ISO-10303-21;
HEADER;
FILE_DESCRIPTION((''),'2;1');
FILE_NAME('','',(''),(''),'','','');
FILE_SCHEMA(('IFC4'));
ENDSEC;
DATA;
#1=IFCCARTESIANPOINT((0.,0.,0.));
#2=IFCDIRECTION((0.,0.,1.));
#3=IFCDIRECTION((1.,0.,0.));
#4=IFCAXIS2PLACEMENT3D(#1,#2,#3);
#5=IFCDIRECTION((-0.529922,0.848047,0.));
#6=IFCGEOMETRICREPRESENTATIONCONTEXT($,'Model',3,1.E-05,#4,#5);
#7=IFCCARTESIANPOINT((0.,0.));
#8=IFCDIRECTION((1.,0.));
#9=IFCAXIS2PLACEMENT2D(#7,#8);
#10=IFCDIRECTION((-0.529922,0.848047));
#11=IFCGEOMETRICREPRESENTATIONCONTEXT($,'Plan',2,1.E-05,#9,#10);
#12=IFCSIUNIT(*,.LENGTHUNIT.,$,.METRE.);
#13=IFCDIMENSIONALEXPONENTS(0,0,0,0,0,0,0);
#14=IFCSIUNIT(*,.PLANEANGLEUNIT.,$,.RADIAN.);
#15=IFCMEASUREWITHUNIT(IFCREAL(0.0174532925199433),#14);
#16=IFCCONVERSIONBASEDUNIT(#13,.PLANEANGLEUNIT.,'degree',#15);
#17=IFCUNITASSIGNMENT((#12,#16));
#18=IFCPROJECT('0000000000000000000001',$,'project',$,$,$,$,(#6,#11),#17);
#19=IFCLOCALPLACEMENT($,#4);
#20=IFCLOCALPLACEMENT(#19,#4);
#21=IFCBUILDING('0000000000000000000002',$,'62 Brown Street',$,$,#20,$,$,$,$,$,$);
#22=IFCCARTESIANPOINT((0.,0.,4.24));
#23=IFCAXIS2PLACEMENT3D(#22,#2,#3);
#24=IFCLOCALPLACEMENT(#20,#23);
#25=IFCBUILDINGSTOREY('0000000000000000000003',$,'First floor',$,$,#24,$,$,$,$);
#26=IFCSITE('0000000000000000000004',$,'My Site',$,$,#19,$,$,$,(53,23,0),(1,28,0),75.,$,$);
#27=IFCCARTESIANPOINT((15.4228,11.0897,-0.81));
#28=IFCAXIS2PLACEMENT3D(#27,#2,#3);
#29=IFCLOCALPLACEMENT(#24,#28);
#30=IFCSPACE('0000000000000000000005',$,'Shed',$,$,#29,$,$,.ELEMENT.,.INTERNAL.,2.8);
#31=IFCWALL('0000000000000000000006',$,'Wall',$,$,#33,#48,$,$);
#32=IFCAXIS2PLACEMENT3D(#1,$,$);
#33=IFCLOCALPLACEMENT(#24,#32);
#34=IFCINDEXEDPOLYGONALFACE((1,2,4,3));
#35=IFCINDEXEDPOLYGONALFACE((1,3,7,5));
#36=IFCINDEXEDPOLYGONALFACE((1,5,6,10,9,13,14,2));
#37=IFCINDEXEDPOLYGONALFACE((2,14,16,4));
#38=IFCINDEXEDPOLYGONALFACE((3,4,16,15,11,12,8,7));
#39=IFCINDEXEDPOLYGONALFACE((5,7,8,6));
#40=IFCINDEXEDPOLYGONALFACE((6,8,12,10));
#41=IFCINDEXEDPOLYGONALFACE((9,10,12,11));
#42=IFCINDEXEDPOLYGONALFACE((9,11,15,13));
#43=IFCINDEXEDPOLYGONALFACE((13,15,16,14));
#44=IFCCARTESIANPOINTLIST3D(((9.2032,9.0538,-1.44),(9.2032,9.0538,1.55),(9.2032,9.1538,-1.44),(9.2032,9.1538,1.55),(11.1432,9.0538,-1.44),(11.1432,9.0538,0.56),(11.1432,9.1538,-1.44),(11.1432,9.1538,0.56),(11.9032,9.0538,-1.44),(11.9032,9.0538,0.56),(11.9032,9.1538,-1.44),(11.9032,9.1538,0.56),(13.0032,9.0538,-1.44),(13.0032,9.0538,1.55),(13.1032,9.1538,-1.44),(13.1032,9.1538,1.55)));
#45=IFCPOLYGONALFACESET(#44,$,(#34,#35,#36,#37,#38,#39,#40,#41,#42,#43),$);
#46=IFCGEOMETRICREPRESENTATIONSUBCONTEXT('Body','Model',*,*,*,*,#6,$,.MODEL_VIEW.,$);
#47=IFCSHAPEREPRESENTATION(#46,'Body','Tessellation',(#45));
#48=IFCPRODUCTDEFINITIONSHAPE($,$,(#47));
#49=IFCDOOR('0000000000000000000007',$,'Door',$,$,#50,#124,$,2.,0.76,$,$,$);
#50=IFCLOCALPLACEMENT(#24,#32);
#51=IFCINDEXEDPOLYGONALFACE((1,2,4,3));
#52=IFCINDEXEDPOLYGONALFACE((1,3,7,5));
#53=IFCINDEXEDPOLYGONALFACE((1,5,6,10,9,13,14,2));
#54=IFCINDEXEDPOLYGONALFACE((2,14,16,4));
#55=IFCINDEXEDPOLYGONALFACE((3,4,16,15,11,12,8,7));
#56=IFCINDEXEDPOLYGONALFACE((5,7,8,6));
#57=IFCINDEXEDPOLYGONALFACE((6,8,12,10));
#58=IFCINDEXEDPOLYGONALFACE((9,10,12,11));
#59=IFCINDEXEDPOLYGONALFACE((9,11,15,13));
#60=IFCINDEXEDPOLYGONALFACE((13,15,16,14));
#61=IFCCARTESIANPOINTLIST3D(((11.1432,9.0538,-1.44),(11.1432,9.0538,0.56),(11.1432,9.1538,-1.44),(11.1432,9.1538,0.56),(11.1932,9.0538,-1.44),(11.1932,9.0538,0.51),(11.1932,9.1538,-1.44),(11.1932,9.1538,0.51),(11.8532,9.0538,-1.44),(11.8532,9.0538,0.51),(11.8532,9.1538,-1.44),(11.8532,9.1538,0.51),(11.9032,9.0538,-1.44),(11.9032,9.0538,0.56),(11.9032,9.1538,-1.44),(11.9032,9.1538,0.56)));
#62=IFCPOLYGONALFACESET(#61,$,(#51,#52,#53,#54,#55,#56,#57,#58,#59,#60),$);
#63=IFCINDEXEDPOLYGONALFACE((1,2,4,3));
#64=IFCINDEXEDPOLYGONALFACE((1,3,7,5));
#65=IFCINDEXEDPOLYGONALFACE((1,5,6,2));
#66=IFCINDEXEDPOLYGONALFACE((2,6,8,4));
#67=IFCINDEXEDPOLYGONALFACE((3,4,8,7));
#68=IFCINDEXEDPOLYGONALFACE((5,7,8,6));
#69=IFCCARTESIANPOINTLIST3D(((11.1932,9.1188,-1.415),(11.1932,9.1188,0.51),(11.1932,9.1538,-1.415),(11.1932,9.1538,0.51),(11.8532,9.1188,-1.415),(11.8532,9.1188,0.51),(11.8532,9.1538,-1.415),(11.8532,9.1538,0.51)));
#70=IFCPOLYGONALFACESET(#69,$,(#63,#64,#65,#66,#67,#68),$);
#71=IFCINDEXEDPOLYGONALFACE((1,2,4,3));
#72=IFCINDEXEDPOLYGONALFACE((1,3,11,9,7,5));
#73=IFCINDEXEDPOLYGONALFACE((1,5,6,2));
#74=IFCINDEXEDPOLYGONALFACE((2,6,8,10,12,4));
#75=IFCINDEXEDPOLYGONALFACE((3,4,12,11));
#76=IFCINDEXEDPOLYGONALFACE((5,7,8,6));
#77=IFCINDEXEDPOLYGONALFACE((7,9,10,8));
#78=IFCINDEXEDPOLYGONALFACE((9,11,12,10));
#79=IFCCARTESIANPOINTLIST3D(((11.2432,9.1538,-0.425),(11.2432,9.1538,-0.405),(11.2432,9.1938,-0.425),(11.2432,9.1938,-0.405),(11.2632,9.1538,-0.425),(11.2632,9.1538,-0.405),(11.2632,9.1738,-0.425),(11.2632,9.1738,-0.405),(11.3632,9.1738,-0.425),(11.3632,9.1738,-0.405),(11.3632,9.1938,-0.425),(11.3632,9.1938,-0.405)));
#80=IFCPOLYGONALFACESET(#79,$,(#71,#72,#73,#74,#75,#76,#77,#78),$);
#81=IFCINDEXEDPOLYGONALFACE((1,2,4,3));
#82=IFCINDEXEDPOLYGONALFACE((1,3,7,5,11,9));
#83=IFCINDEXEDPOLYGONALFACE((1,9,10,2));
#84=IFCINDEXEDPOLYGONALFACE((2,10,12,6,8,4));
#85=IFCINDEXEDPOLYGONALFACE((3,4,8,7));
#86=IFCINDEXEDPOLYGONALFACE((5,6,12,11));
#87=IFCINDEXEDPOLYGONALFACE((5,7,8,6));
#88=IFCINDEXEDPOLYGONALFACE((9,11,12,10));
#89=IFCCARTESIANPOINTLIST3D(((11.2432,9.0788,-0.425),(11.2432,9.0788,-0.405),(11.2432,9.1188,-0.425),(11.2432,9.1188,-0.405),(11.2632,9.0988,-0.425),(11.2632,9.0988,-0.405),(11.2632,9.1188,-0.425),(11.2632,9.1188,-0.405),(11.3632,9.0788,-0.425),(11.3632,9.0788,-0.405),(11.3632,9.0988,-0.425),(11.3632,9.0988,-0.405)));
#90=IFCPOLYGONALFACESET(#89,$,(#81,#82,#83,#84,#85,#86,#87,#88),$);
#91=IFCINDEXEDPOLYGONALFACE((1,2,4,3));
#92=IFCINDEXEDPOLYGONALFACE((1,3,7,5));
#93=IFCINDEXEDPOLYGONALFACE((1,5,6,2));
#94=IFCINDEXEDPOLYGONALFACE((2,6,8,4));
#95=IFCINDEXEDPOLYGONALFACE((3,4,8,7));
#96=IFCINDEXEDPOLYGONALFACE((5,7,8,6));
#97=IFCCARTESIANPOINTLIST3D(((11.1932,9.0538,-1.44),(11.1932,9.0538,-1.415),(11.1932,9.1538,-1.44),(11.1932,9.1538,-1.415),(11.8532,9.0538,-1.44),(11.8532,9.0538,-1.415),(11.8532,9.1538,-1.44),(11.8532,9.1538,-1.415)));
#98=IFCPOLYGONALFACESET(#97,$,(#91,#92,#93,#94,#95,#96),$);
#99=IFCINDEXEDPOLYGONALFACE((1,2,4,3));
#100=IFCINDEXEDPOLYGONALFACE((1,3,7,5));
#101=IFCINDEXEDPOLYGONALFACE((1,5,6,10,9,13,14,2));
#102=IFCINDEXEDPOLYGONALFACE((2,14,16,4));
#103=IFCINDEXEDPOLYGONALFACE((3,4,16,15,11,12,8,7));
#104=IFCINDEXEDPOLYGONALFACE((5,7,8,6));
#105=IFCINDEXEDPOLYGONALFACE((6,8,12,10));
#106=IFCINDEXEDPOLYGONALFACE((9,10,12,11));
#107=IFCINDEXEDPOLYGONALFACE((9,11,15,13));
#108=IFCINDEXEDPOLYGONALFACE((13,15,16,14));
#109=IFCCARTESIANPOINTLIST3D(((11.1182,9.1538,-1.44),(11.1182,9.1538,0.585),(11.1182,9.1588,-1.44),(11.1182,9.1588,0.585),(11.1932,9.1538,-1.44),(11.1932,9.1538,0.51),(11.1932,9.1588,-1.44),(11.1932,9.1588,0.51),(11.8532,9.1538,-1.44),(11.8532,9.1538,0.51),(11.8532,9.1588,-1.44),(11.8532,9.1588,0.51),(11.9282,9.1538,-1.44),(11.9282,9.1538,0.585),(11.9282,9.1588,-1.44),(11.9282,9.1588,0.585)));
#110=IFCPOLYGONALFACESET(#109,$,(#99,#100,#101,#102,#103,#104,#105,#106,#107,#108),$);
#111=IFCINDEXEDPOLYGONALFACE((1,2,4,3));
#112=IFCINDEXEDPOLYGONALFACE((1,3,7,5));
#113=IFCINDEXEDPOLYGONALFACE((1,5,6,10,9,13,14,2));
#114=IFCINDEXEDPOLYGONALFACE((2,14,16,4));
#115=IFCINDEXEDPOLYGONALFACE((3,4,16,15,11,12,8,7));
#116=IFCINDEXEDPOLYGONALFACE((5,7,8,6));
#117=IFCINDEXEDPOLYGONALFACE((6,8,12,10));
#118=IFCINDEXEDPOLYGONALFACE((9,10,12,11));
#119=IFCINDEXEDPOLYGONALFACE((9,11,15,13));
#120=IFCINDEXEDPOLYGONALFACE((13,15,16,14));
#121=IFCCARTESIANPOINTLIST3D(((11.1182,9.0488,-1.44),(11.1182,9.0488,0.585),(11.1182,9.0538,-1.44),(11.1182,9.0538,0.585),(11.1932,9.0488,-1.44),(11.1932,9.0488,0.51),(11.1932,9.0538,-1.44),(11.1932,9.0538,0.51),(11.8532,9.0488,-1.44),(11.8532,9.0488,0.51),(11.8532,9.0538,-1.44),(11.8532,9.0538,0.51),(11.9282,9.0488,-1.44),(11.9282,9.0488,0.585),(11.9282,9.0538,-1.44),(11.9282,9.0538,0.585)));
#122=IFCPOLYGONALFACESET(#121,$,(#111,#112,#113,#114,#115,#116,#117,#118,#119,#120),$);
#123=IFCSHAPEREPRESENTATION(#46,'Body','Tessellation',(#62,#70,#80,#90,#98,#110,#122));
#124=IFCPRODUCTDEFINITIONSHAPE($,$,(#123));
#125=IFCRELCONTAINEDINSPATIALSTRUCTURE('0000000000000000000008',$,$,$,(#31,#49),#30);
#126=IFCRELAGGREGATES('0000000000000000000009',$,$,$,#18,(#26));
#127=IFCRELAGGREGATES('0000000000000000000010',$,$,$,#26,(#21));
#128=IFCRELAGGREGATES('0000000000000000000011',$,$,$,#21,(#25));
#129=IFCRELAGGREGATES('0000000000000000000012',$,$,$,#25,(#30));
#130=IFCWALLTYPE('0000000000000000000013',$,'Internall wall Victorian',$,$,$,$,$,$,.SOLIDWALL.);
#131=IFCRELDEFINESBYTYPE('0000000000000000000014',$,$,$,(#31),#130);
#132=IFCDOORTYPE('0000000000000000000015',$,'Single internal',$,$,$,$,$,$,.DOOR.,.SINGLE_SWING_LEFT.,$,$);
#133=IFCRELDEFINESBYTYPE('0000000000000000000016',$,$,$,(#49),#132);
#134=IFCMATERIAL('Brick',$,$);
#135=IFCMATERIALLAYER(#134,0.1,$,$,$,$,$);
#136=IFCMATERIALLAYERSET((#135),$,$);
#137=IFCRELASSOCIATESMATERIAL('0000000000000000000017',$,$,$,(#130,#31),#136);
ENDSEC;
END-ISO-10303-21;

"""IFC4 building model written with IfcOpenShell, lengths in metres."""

from ifc_helpers import new_model, entity, si_unit, converted_unit, direction, frame, origin_with_axes, origin_2d_with_axis, place, context, subcontext, project, spatial, line, indexed_curve, outline, extrude, clip, halfspace, shape, source, transform, mapped, material, layer, layer_set, layer_usage, type_object, type_shapes, element, fill, save


model = new_model("IFC4")

# Units and contexts
model_context = context("Model", 3, precision=1e-05, world=origin_with_axes(), true_north=direction((-0.529922, 0.848047, 0.0)))
plan_context = context("Plan", 2, precision=1e-05, world=origin_2d_with_axis(), true_north=direction((-0.529922, 0.848047)))
body_context_1 = subcontext(model_context, "Body", "Model", "MODEL_VIEW")
body_context_2 = subcontext(plan_context, "Body", "Plan", "PLAN_VIEW")
ifc_project = project(units=[si_unit("LENGTHUNIT", "METRE"), converted_unit("PLANEANGLEUNIT", "degree", entity("IfcReal", 0.0174532925199433), si_unit("PLANEANGLEUNIT", "RADIAN"), dimensions=[0, 0, 0, 0, 0, 0, 0])], contexts=[model_context, plan_context])

# Site, building, storey, space
site_placement = place(None, origin_with_axes())
site = spatial("IfcSite", under=ifc_project, at=site_placement, Name="My Site", RefLatitude=(53, 23, 0), RefLongitude=(1, 28, 0), RefElevation=75.0)
building_placement = place(site_placement, origin_with_axes())
building = spatial("IfcBuilding", under=site, at=building_placement, Name="62 Brown Street")
storey_placement = place(building_placement, frame((0.0, 0.0, 4.24), z_axis=(0.0, 0.0, 1.0), x_axis=(1.0, 0.0, 0.0)))
storey = spatial("IfcBuildingStorey", under=building, at=storey_placement, Name="First floor")
space_placement = place(storey_placement, frame((15.4228, 11.0897, -0.81), z_axis=(0.0, 0.0, 1.0), x_axis=(1.0, 0.0, 0.0)))
space = spatial("IfcSpace", under=storey, at=space_placement, Name="Shed", CompositionType="ELEMENT", PredefinedType="INTERNAL", ElevationWithFlooring=2.8)

# Shared definitions
ifc_material_1 = material(Name="Brick")
ifc_layer_1 = layer(ifc_material_1, 0.1)
ifc_layer_set_1 = layer_set([ifc_layer_1])
wall_type_1 = type_object("IfcWallType", Name="Internall wall Victorian", PredefinedType="SOLIDWALL", material=ifc_layer_set_1)

# Wall, opening, door
ifc_layer_usage_1 = layer_usage(ifc_layer_set_1, "AXIS2", "POSITIVE", 0.0)
wall_1_placement = place(None, frame((13.1032, 9.1538, 2.8), z_axis=(0.0, 0.0, 1.0), x_axis=(-1.0, 0.0, 0.0)))
wall_1 = element("IfcWall", 1, at=wall_1_placement, inside=space, type_object=wall_type_1, material=ifc_layer_usage_1, Name="Wall", context=body_context_1, shape_type="Clipping", body=[
    clip(extrude(outline(indexed_curve([(0.0, 0.0), (0.0, 0.1), (3.9, 0.1), (3.9, 0.0), (0.0, 0.0)], self_intersect=False)), origin_with_axes(), (0.0, 0.0, 1.0), 2.99), halfspace(frame((0.0, 0.0, -2.8), z_axis=(-0.707104, 0.70711, 0.0), x_axis=(0.70711, 0.707104, 0.0)), False)),
])
shared_shape_1 = source(origin_with_axes(), body_context_1, "Body", "SweptSolid", [
    extrude(outline(indexed_curve([(0.0, 0.0), (0.76, 0.0), (0.76, 2.0), (0.0, 2.0)], segments=[line(1, 2, 3, 4, 1)])), frame((0.0, -0.6, 0.0), z_axis=(0.0, -1.0, 0.0), x_axis=(1.0, 0.0, 0.0)), (0.0, 0.0, -1.0), 1.2),
])
opening_placement = place(wall_1_placement, frame((1.2, 0.0, 0.0), z_axis=(0.0, 0.0, 1.0), x_axis=(1.0, 0.0, 0.0)))
opening = element("IfcOpeningElement", 2, at=opening_placement, cuts=wall_1, PredefinedType="OPENING", context=body_context_1, shape_type="MappedRepresentation", body=[
    mapped(shared_shape_1, transform((0.0, 0.0, 0.0), x_axis=(1.0, 0.0, 0.0), y_axis=(0.0, 1.0, 0.0), z_axis=(0.0, 0.0, 1.0), scale=1.0)),
])
door_type = type_object("IfcDoorType", Name="Single internal", OperationType="SINGLE_SWING_LEFT", PredefinedType="DOOR")
shared_shape_2 = source(origin_with_axes(), body_context_1, "Body", "SweptSolid", [
    extrude(outline(indexed_curve([(0.0, 0.0), (0.0, 2.0), (0.76, 2.0), (0.76, 0.0), (0.71, 0.0), (0.71, 1.95), (0.05, 1.95), (0.05, 0.0)], segments=[line(1, 2, 3, 4, 5, 6, 7, 8, 1)])), frame((0.0, 0.0, 0.0), z_axis=(0.0, -1.0, 0.0), x_axis=(1.0, 0.0, 0.0)), (0.0, 0.0, -1.0), 0.1),
    extrude(outline(indexed_curve([(0.0, 0.0), (0.66, 0.0), (0.66, 0.035), (0.0, 0.035)], segments=[line(1, 2, 3, 4, 1)])), frame((0.05, 0.0, 0.025), z_axis=(0.0, 0.0, 1.0), x_axis=(1.0, 0.0, 0.0)), (0.0, 0.0, 1.0), 1.925),
    extrude(outline(indexed_curve([(0.0, 0.0), (0.0, -0.04), (-0.12, -0.04), (-0.12, -0.02), (-0.02, -0.02), (-0.02, 0.0)], segments=[line(1, 2, 3, 4, 5, 6, 1)])), frame((0.66, 0.0, 1.015), z_axis=(0.0, 0.0, 1.0), x_axis=(1.0, 0.0, 0.0)), (0.0, 0.0, 1.0), 0.02),
    extrude(outline(indexed_curve([(0.0, 0.0), (0.0, 0.04), (-0.12, 0.04), (-0.12, 0.02), (-0.02, 0.02), (-0.02, 0.0)], segments=[line(1, 2, 3, 4, 5, 6, 1)])), frame((0.66, 0.035, 1.015), z_axis=(0.0, 0.0, 1.0), x_axis=(1.0, 0.0, 0.0)), (0.0, 0.0, 1.0), 0.02),
    extrude(outline(indexed_curve([(0.0, 0.0), (0.66, 0.0), (0.66, 0.1), (0.0, 0.1)], segments=[line(1, 2, 3, 4, 1)])), frame((0.05, 0.0, 0.0), z_axis=(0.0, 0.0, 1.0), x_axis=(1.0, 0.0, 0.0)), (0.0, 0.0, 1.0), 0.025),
    extrude(outline(indexed_curve([(0.0, 0.0), (0.0, 2.025), (0.81, 2.025), (0.81, 0.0), (0.735, 0.0), (0.735, 1.95), (0.075, 1.95), (0.075, 0.0)], segments=[line(1, 2, 3, 4, 5, 6, 7, 8, 1)])), frame((-0.025, -0.005, 0.0), z_axis=(0.0, -1.0, 0.0), x_axis=(1.0, 0.0, 0.0)), (0.0, 0.0, -1.0), 0.005),
    extrude(outline(indexed_curve([(0.0, 0.0), (0.0, 2.025), (0.81, 2.025), (0.81, 0.0), (0.735, 0.0), (0.735, 1.95), (0.075, 1.95), (0.075, 0.0)], segments=[line(1, 2, 3, 4, 5, 6, 7, 8, 1)])), frame((-0.025, 0.1, 0.0), z_axis=(0.0, -1.0, 0.0), x_axis=(1.0, 0.0, 0.0)), (0.0, 0.0, -1.0), 0.005),
])
shared_shape_3 = source(origin_with_axes(), body_context_2, "Body", "Curve2D", [
    entity("IfcIndexedPolyCurve", entity("IfcCartesianPointList2D", [[0.0, 0.0], [0.05, 0.0], [0.05, 0.1], [0.0, 0.1]]), [entity("IfcLineIndex", [1, 2, 3, 4, 1])]),
    entity("IfcIndexedPolyCurve", entity("IfcCartesianPointList2D", [[0.76, 0.0], [0.71, 0.0], [0.71, 0.1], [0.76, 0.1]]), [entity("IfcLineIndex", [1, 2, 3, 4, 1])]),
    entity("IfcTrimmedCurve", entity("IfcEllipse", entity("IfcAxis2Placement2D", entity("IfcCartesianPoint", [0.085, 0.1]), entity("IfcDirection", [1.0, 0.0])), 0.625, 0.66), [entity("IfcCartesianPoint", [0.71, 0.1])], [entity("IfcCartesianPoint", [0.085, 0.76])], True, "CARTESIAN"),
    entity("IfcIndexedPolyCurve", entity("IfcCartesianPointList2D", [[0.05, 0.1], [0.085, 0.1], [0.085, 0.76], [0.05, 0.76]]), [entity("IfcLineIndex", [1, 2, 3, 4, 1])]),
])
type_shapes(door_type, [shared_shape_2, shared_shape_3])
door_placement = place(opening_placement, frame((0.0, 0.0, 0.0), z_axis=(0.0, 0.0, 1.0), x_axis=(1.0, 0.0, 0.0)))
door = element("IfcDoor", 3, at=door_placement, inside=space, type_object=door_type, Name="Door", OverallHeight=2.0, OverallWidth=0.76, shapes=[
    shape(body_context_1, "Body", "MappedRepresentation", [mapped(shared_shape_2, transform((0.0, 0.0, 0.0), x_axis=(1.0, 0.0, 0.0), y_axis=(0.0, 1.0, 0.0), z_axis=(0.0, 0.0, 1.0), scale=1.0))]),
    shape(body_context_2, "Body", "MappedRepresentation", [mapped(shared_shape_3, transform((0.0, 0.0, 0.0), x_axis=(1.0, 0.0, 0.0), y_axis=(0.0, 1.0, 0.0), z_axis=(0.0, 0.0, 1.0), scale=1.0))]),
])
fill(opening, door)

save(model, "model.ifc")
